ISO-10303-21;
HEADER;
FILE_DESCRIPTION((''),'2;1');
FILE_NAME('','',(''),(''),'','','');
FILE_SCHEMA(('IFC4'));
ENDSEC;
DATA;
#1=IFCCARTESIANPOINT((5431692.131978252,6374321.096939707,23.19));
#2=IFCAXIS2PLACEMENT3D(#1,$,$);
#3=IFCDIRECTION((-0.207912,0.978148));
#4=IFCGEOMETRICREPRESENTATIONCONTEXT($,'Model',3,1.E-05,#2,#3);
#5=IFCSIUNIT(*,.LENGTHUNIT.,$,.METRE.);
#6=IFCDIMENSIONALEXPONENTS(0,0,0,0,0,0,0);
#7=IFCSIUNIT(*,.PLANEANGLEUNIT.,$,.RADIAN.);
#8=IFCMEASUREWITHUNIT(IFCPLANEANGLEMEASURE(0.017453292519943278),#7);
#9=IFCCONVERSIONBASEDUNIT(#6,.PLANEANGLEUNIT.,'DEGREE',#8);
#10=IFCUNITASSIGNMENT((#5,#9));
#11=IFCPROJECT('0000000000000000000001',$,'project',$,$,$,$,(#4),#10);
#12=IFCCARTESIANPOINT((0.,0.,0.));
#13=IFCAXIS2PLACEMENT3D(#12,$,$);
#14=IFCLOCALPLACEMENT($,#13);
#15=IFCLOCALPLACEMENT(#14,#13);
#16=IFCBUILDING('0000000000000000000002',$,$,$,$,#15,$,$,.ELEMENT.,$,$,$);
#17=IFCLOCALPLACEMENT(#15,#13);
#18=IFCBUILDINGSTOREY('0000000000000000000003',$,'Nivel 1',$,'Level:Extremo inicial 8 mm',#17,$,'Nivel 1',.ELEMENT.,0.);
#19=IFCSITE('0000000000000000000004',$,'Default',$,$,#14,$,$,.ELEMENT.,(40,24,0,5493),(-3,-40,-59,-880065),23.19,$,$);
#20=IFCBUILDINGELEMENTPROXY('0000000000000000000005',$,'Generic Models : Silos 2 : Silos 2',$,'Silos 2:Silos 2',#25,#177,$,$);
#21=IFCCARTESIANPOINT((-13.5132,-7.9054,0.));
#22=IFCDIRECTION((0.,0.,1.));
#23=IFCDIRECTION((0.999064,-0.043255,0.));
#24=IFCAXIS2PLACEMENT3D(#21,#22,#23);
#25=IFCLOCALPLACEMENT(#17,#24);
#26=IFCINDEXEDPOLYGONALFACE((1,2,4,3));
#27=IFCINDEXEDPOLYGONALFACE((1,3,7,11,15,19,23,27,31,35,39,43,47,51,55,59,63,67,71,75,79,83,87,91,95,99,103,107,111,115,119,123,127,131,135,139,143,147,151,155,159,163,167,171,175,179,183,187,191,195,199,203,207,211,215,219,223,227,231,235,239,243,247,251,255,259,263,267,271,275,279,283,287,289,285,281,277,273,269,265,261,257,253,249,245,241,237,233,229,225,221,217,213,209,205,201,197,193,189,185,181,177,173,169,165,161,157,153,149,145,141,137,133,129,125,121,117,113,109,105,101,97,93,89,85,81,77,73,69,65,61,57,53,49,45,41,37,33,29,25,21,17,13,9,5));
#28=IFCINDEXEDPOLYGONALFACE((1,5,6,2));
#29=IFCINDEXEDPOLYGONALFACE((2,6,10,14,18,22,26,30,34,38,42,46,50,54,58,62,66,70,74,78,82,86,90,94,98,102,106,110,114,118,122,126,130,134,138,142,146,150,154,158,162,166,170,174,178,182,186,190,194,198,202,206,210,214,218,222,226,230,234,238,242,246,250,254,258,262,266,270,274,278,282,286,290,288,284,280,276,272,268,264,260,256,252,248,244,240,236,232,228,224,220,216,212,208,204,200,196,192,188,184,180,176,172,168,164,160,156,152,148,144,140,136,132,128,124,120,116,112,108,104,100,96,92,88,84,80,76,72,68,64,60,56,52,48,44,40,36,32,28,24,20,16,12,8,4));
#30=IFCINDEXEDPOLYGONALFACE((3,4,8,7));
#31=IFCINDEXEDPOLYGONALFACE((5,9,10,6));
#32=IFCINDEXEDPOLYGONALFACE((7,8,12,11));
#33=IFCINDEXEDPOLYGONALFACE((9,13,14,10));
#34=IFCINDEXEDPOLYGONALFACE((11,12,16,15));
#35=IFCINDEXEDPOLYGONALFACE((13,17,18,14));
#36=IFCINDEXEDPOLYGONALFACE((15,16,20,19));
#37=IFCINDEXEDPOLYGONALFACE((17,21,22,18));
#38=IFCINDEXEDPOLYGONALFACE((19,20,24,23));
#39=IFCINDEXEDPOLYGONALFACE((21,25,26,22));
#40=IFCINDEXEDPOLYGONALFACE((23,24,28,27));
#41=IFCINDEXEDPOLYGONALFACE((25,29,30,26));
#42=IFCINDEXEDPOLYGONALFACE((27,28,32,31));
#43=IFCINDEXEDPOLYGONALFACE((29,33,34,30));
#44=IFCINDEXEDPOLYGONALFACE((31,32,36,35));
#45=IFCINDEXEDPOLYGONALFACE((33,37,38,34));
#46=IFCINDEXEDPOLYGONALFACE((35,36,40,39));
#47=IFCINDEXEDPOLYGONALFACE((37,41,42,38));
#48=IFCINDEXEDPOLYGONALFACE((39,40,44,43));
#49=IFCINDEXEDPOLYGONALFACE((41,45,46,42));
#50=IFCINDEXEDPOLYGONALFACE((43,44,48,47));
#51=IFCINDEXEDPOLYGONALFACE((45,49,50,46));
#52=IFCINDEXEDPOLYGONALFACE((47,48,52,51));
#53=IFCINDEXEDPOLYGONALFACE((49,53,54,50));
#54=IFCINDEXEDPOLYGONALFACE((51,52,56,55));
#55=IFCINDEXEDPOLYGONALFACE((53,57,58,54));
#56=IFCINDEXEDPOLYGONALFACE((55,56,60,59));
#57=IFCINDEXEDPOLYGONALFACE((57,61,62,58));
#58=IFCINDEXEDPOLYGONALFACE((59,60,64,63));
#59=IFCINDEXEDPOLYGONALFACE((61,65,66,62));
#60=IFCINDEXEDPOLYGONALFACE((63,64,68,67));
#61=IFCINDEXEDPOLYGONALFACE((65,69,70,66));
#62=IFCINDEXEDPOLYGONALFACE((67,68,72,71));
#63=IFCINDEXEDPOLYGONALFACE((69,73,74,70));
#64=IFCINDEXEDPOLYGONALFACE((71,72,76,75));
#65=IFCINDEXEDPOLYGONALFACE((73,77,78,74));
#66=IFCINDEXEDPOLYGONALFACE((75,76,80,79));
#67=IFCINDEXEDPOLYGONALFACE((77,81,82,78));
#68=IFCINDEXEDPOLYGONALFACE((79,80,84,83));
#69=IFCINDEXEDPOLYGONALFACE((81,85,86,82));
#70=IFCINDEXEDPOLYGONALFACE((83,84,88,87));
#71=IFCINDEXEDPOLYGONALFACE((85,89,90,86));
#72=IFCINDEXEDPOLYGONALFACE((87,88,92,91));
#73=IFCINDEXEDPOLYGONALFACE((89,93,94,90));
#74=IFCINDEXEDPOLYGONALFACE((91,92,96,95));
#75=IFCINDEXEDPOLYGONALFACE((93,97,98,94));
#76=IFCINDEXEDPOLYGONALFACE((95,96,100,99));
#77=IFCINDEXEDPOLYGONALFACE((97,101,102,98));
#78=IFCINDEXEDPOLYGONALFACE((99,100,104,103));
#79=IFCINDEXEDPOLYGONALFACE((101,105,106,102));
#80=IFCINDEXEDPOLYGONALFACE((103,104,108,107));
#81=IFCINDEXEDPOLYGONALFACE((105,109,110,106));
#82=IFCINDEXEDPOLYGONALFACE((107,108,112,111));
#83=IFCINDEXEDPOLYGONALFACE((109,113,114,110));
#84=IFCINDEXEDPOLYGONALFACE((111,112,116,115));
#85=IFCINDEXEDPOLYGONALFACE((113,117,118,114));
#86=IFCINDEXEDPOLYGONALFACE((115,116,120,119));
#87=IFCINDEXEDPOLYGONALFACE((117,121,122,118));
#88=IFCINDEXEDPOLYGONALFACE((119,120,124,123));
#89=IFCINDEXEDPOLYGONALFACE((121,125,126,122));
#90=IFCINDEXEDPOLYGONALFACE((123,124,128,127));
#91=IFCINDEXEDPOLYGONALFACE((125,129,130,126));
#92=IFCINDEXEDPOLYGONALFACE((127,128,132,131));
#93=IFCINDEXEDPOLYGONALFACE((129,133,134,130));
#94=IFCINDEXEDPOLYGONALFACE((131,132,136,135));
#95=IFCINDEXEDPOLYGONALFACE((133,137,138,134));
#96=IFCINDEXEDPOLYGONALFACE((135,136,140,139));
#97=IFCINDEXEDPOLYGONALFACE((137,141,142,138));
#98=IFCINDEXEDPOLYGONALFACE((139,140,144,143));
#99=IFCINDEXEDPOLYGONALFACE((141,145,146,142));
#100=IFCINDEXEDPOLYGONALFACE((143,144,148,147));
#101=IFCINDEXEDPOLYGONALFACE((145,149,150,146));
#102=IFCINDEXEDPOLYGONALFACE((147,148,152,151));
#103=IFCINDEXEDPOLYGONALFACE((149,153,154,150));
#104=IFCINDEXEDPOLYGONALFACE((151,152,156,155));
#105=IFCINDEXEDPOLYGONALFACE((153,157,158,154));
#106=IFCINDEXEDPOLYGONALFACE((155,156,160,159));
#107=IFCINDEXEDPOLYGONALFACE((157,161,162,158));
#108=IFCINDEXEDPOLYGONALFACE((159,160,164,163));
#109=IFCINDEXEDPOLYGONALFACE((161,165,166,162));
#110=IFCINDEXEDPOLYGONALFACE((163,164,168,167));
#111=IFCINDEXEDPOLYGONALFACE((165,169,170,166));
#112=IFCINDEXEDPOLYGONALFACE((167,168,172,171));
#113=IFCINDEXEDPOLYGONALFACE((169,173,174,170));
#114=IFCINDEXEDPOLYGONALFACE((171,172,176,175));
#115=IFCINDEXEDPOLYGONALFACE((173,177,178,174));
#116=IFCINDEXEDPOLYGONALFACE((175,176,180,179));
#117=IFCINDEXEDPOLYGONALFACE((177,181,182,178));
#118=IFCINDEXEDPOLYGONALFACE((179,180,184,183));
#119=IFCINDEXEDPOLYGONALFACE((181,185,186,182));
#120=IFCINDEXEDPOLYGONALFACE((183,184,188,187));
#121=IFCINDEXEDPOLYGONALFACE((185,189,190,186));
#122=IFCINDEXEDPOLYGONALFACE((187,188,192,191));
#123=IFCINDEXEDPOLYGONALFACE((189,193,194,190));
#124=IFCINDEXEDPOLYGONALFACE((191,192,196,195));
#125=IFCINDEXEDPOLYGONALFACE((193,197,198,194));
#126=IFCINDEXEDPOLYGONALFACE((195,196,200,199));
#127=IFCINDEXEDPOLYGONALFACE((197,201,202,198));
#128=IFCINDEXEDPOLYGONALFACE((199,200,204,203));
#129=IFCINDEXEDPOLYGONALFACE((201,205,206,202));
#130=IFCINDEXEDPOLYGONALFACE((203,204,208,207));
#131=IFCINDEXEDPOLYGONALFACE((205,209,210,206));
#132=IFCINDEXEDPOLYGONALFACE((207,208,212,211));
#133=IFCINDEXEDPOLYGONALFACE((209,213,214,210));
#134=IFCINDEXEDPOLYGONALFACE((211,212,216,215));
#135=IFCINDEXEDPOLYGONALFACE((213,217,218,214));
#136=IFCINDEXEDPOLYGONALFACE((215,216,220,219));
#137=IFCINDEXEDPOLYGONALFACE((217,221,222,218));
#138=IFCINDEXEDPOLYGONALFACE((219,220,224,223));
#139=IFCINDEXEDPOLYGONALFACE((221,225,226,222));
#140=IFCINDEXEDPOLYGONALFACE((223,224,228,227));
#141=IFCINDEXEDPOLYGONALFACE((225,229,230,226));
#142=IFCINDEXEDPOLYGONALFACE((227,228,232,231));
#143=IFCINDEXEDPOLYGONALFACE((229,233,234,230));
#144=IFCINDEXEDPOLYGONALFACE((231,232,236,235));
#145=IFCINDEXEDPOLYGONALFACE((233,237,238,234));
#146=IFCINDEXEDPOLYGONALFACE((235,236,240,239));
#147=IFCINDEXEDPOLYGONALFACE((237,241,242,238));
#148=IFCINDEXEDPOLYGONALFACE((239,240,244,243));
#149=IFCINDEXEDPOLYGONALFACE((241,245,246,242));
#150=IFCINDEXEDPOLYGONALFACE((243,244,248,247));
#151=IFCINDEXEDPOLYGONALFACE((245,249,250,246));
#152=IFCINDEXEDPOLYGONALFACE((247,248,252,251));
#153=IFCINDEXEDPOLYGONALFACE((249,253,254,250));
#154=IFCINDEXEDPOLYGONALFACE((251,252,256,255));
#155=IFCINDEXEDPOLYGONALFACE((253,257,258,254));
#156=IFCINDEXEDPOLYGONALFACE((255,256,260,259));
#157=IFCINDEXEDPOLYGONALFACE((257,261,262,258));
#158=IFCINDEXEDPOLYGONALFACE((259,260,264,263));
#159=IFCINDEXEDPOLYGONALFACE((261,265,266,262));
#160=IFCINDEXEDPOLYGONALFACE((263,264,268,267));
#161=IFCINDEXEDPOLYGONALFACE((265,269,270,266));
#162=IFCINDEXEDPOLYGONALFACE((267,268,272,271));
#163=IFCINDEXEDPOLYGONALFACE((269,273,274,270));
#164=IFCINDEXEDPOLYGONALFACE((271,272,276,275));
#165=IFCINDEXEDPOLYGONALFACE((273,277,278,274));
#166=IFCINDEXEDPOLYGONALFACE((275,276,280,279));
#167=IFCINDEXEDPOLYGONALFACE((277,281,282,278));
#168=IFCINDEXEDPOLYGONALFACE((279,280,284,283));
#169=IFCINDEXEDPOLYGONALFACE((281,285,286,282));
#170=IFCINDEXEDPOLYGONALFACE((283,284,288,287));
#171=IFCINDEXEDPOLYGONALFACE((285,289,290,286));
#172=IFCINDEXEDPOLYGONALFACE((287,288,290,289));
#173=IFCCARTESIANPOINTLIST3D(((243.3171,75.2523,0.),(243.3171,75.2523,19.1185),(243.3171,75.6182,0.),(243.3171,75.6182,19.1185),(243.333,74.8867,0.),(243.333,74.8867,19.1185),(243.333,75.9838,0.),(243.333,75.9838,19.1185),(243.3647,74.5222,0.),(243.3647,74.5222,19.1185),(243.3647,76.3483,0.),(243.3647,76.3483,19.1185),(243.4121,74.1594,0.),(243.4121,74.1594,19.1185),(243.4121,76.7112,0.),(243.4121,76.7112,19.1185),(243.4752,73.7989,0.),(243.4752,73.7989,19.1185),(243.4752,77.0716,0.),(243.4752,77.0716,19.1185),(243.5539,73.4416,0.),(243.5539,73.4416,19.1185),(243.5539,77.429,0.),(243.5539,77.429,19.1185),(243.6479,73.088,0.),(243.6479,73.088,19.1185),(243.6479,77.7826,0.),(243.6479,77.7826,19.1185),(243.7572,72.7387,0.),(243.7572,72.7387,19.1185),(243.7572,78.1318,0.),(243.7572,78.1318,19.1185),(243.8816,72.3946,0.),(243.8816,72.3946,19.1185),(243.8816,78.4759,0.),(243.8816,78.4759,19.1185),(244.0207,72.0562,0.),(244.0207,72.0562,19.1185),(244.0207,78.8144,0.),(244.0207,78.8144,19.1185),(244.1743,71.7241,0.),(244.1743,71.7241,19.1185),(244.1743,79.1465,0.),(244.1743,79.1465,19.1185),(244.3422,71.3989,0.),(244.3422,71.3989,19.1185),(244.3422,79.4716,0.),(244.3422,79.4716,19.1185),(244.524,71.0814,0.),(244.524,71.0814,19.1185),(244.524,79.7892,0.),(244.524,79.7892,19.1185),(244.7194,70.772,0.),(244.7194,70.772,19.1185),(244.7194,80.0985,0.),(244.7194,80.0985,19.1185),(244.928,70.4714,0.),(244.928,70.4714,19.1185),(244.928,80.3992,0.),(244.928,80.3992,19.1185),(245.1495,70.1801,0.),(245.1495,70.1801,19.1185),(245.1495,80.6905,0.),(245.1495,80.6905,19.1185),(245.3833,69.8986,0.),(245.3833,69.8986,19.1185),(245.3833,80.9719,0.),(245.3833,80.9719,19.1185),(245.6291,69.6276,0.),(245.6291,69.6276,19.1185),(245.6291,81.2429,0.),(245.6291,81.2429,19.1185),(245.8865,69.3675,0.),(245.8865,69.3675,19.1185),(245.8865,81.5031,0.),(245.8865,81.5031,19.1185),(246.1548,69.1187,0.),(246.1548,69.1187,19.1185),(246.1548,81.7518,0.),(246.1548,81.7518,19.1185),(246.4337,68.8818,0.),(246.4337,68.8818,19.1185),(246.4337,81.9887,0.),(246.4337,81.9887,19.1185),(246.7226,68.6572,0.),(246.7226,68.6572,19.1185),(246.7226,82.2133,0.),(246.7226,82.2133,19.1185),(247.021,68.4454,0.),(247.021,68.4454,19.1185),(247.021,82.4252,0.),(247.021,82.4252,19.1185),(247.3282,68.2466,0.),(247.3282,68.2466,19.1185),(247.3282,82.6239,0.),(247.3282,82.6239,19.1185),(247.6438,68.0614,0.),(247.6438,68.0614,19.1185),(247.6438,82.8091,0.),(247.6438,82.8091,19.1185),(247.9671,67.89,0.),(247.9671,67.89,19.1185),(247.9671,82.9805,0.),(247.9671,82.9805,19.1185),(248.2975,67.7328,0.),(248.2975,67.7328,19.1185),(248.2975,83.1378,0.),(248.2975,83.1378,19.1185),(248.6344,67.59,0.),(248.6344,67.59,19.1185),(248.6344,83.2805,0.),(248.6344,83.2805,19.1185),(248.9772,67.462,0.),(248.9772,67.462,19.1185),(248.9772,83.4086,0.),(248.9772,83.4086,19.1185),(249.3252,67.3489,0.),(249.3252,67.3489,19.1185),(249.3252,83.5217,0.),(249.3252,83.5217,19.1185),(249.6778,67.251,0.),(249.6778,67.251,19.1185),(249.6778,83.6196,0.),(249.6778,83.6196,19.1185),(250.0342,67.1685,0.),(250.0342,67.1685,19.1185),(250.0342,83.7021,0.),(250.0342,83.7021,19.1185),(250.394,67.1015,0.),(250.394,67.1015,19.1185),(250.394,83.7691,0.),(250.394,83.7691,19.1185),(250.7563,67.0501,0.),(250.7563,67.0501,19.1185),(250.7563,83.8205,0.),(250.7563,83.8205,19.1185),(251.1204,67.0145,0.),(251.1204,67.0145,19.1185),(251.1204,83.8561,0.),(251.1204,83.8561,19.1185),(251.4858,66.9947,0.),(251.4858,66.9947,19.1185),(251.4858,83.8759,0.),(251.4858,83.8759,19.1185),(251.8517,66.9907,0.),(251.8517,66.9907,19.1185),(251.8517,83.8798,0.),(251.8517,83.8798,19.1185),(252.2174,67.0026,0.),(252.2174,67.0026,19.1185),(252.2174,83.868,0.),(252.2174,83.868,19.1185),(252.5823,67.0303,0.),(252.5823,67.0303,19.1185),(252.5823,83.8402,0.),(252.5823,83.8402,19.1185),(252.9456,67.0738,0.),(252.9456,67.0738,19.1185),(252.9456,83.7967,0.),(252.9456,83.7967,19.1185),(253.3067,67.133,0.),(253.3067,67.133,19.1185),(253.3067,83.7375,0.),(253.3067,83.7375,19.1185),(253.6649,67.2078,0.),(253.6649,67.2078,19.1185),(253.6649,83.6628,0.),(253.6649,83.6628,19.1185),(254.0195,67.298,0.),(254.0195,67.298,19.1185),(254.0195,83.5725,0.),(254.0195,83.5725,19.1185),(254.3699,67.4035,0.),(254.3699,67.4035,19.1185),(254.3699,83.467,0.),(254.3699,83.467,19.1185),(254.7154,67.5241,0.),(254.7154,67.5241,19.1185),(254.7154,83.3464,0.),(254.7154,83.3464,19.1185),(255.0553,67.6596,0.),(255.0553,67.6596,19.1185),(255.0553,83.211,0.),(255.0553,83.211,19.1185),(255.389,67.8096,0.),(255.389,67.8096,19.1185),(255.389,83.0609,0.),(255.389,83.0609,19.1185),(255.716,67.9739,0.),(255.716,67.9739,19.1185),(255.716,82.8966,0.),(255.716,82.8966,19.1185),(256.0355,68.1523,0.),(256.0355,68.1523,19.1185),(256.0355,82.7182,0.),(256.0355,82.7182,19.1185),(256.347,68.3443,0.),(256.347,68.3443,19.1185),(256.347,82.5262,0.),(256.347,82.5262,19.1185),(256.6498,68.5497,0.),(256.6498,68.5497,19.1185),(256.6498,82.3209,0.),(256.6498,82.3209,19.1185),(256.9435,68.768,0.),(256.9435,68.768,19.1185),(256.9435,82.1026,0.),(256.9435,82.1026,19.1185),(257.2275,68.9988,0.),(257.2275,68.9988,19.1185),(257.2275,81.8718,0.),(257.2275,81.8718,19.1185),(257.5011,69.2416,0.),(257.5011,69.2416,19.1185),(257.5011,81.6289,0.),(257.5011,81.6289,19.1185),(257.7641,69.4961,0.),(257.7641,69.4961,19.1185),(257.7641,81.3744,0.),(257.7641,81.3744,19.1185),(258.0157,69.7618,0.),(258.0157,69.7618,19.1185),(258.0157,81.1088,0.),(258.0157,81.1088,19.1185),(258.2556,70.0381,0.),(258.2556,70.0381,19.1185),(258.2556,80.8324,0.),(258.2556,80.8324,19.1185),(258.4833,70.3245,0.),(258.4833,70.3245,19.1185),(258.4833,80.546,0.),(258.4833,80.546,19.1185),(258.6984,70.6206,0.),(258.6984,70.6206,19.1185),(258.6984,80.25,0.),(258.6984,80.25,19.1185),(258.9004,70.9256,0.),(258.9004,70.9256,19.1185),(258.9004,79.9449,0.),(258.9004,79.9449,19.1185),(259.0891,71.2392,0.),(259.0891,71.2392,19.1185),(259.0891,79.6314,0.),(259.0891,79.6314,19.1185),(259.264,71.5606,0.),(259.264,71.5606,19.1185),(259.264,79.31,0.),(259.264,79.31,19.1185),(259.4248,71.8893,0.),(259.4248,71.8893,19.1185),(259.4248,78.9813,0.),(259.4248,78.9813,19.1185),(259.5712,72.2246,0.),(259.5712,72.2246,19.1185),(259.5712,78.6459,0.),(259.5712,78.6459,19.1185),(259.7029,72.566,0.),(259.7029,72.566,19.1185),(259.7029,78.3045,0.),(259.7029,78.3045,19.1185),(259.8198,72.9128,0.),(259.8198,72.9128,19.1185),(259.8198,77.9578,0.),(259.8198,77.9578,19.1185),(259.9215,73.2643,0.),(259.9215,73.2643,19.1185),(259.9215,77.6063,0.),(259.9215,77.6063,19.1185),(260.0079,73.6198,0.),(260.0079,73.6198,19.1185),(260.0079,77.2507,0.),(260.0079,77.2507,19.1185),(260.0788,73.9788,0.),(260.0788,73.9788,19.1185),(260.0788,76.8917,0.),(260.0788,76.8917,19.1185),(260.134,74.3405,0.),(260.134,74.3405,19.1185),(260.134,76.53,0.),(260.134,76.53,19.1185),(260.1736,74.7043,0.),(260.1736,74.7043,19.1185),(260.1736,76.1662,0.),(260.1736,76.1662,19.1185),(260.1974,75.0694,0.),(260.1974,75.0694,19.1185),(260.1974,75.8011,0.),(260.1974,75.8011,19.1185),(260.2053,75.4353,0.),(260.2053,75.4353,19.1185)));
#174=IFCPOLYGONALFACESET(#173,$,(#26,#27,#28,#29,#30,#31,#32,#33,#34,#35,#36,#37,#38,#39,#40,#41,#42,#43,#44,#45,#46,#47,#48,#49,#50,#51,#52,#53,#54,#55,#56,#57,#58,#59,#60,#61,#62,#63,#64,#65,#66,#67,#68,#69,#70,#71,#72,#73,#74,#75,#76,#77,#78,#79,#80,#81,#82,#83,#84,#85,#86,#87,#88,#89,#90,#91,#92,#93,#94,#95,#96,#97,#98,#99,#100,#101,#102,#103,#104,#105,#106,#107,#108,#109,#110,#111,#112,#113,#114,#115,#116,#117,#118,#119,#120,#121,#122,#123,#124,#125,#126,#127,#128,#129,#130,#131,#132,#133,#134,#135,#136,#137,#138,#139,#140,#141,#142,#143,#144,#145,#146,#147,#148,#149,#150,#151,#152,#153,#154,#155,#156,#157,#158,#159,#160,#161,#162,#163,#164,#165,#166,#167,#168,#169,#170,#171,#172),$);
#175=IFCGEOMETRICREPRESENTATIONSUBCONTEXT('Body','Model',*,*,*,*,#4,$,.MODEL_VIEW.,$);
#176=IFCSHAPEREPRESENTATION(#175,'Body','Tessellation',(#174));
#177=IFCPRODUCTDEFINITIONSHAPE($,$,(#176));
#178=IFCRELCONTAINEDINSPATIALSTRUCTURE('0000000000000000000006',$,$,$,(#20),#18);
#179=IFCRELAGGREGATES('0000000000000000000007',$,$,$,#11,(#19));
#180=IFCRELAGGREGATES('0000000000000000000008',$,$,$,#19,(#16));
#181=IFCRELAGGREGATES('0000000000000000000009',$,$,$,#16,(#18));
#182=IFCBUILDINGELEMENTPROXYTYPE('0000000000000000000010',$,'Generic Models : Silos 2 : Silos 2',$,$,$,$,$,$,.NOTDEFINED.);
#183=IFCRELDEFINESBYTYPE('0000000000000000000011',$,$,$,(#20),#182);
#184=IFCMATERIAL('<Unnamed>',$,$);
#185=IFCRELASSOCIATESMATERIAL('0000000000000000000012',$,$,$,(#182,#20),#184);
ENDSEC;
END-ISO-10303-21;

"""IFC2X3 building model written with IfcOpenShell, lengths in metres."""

from ifc_helpers import new_model, entity, si_unit, converted_unit, direction, frame, frame_2d, origin, place, context, subcontext, project, spatial, circle, extrude, source, transform, mapped, material, type_object, type_shapes, element, save


model = new_model("IFC2X3")

# Units and contexts
model_context = context("Model", 3, precision=1e-05, world=frame((5431692.131978252, 6374321.096939707, 23.19)), true_north=direction((-0.207912, 0.978148)))
body_context = subcontext(model_context, "Body", "Model", "MODEL_VIEW")
ifc_project = project(units=[si_unit("LENGTHUNIT", "METRE"), converted_unit("PLANEANGLEUNIT", "DEGREE", entity("IfcPlaneAngleMeasure", 0.017453292519943278), si_unit("PLANEANGLEUNIT", "RADIAN"), dimensions=[0, 0, 0, 0, 0, 0, 0])], contexts=[model_context])

# Site, building, storey
site_placement = place(None, origin())
site = spatial("IfcSite", under=ifc_project, at=site_placement, Name="Default", CompositionType="ELEMENT", RefLatitude=(40, 24, 0, 5493), RefLongitude=(-3, -40, -59, -880065), RefElevation=23.19)
building_placement = place(site_placement, origin())
building = spatial("IfcBuilding", under=site, at=building_placement, CompositionType="ELEMENT")
storey_placement = place(building_placement, origin())
storey = spatial("IfcBuildingStorey", under=building, at=storey_placement, Name="Nivel 1", ObjectType="Level:Extremo inicial 8 mm", LongName="Nivel 1", CompositionType="ELEMENT", Elevation=0.0)

# Building element proxy
ifc_material_1 = material(Name="<Unnamed>")
building_element_proxy_type_1 = type_object("IfcBuildingElementProxyType", Name="Generic Models : Silos 2 : Silos 2", PredefinedType="NOTDEFINED", material=ifc_material_1)
shared_shape_1 = source(origin(), body_context, "Body", "SweptSolid", [
    extrude(circle(Radius=8.4451, at=frame_2d((0.0, 0.0), x_axis=(1.0, 0.0))), frame((251.7602, 75.4353, 0.0)), (0.0, 0.0, 1.0), 19.1185),
])
type_shapes(building_element_proxy_type_1, [shared_shape_1])
proxy_1_placement = place(storey_placement, frame((-13.5132, -7.9054, 0.0), z_axis=(0.0, 0.0, 1.0), x_axis=(0.999064, -0.043255, 0.0)))
element("IfcBuildingElementProxy", 1, at=proxy_1_placement, inside=storey, type_object=building_element_proxy_type_1, material=ifc_material_1, Name="Generic Models : Silos 2 : Silos 2", ObjectType="Silos 2:Silos 2", context=body_context, shape_type="MappedRepresentation", body=[
    mapped(shared_shape_1, transform((0.0, 0.0, 0.0), scale=1.0)),
])

save(model, "model.ifc")
